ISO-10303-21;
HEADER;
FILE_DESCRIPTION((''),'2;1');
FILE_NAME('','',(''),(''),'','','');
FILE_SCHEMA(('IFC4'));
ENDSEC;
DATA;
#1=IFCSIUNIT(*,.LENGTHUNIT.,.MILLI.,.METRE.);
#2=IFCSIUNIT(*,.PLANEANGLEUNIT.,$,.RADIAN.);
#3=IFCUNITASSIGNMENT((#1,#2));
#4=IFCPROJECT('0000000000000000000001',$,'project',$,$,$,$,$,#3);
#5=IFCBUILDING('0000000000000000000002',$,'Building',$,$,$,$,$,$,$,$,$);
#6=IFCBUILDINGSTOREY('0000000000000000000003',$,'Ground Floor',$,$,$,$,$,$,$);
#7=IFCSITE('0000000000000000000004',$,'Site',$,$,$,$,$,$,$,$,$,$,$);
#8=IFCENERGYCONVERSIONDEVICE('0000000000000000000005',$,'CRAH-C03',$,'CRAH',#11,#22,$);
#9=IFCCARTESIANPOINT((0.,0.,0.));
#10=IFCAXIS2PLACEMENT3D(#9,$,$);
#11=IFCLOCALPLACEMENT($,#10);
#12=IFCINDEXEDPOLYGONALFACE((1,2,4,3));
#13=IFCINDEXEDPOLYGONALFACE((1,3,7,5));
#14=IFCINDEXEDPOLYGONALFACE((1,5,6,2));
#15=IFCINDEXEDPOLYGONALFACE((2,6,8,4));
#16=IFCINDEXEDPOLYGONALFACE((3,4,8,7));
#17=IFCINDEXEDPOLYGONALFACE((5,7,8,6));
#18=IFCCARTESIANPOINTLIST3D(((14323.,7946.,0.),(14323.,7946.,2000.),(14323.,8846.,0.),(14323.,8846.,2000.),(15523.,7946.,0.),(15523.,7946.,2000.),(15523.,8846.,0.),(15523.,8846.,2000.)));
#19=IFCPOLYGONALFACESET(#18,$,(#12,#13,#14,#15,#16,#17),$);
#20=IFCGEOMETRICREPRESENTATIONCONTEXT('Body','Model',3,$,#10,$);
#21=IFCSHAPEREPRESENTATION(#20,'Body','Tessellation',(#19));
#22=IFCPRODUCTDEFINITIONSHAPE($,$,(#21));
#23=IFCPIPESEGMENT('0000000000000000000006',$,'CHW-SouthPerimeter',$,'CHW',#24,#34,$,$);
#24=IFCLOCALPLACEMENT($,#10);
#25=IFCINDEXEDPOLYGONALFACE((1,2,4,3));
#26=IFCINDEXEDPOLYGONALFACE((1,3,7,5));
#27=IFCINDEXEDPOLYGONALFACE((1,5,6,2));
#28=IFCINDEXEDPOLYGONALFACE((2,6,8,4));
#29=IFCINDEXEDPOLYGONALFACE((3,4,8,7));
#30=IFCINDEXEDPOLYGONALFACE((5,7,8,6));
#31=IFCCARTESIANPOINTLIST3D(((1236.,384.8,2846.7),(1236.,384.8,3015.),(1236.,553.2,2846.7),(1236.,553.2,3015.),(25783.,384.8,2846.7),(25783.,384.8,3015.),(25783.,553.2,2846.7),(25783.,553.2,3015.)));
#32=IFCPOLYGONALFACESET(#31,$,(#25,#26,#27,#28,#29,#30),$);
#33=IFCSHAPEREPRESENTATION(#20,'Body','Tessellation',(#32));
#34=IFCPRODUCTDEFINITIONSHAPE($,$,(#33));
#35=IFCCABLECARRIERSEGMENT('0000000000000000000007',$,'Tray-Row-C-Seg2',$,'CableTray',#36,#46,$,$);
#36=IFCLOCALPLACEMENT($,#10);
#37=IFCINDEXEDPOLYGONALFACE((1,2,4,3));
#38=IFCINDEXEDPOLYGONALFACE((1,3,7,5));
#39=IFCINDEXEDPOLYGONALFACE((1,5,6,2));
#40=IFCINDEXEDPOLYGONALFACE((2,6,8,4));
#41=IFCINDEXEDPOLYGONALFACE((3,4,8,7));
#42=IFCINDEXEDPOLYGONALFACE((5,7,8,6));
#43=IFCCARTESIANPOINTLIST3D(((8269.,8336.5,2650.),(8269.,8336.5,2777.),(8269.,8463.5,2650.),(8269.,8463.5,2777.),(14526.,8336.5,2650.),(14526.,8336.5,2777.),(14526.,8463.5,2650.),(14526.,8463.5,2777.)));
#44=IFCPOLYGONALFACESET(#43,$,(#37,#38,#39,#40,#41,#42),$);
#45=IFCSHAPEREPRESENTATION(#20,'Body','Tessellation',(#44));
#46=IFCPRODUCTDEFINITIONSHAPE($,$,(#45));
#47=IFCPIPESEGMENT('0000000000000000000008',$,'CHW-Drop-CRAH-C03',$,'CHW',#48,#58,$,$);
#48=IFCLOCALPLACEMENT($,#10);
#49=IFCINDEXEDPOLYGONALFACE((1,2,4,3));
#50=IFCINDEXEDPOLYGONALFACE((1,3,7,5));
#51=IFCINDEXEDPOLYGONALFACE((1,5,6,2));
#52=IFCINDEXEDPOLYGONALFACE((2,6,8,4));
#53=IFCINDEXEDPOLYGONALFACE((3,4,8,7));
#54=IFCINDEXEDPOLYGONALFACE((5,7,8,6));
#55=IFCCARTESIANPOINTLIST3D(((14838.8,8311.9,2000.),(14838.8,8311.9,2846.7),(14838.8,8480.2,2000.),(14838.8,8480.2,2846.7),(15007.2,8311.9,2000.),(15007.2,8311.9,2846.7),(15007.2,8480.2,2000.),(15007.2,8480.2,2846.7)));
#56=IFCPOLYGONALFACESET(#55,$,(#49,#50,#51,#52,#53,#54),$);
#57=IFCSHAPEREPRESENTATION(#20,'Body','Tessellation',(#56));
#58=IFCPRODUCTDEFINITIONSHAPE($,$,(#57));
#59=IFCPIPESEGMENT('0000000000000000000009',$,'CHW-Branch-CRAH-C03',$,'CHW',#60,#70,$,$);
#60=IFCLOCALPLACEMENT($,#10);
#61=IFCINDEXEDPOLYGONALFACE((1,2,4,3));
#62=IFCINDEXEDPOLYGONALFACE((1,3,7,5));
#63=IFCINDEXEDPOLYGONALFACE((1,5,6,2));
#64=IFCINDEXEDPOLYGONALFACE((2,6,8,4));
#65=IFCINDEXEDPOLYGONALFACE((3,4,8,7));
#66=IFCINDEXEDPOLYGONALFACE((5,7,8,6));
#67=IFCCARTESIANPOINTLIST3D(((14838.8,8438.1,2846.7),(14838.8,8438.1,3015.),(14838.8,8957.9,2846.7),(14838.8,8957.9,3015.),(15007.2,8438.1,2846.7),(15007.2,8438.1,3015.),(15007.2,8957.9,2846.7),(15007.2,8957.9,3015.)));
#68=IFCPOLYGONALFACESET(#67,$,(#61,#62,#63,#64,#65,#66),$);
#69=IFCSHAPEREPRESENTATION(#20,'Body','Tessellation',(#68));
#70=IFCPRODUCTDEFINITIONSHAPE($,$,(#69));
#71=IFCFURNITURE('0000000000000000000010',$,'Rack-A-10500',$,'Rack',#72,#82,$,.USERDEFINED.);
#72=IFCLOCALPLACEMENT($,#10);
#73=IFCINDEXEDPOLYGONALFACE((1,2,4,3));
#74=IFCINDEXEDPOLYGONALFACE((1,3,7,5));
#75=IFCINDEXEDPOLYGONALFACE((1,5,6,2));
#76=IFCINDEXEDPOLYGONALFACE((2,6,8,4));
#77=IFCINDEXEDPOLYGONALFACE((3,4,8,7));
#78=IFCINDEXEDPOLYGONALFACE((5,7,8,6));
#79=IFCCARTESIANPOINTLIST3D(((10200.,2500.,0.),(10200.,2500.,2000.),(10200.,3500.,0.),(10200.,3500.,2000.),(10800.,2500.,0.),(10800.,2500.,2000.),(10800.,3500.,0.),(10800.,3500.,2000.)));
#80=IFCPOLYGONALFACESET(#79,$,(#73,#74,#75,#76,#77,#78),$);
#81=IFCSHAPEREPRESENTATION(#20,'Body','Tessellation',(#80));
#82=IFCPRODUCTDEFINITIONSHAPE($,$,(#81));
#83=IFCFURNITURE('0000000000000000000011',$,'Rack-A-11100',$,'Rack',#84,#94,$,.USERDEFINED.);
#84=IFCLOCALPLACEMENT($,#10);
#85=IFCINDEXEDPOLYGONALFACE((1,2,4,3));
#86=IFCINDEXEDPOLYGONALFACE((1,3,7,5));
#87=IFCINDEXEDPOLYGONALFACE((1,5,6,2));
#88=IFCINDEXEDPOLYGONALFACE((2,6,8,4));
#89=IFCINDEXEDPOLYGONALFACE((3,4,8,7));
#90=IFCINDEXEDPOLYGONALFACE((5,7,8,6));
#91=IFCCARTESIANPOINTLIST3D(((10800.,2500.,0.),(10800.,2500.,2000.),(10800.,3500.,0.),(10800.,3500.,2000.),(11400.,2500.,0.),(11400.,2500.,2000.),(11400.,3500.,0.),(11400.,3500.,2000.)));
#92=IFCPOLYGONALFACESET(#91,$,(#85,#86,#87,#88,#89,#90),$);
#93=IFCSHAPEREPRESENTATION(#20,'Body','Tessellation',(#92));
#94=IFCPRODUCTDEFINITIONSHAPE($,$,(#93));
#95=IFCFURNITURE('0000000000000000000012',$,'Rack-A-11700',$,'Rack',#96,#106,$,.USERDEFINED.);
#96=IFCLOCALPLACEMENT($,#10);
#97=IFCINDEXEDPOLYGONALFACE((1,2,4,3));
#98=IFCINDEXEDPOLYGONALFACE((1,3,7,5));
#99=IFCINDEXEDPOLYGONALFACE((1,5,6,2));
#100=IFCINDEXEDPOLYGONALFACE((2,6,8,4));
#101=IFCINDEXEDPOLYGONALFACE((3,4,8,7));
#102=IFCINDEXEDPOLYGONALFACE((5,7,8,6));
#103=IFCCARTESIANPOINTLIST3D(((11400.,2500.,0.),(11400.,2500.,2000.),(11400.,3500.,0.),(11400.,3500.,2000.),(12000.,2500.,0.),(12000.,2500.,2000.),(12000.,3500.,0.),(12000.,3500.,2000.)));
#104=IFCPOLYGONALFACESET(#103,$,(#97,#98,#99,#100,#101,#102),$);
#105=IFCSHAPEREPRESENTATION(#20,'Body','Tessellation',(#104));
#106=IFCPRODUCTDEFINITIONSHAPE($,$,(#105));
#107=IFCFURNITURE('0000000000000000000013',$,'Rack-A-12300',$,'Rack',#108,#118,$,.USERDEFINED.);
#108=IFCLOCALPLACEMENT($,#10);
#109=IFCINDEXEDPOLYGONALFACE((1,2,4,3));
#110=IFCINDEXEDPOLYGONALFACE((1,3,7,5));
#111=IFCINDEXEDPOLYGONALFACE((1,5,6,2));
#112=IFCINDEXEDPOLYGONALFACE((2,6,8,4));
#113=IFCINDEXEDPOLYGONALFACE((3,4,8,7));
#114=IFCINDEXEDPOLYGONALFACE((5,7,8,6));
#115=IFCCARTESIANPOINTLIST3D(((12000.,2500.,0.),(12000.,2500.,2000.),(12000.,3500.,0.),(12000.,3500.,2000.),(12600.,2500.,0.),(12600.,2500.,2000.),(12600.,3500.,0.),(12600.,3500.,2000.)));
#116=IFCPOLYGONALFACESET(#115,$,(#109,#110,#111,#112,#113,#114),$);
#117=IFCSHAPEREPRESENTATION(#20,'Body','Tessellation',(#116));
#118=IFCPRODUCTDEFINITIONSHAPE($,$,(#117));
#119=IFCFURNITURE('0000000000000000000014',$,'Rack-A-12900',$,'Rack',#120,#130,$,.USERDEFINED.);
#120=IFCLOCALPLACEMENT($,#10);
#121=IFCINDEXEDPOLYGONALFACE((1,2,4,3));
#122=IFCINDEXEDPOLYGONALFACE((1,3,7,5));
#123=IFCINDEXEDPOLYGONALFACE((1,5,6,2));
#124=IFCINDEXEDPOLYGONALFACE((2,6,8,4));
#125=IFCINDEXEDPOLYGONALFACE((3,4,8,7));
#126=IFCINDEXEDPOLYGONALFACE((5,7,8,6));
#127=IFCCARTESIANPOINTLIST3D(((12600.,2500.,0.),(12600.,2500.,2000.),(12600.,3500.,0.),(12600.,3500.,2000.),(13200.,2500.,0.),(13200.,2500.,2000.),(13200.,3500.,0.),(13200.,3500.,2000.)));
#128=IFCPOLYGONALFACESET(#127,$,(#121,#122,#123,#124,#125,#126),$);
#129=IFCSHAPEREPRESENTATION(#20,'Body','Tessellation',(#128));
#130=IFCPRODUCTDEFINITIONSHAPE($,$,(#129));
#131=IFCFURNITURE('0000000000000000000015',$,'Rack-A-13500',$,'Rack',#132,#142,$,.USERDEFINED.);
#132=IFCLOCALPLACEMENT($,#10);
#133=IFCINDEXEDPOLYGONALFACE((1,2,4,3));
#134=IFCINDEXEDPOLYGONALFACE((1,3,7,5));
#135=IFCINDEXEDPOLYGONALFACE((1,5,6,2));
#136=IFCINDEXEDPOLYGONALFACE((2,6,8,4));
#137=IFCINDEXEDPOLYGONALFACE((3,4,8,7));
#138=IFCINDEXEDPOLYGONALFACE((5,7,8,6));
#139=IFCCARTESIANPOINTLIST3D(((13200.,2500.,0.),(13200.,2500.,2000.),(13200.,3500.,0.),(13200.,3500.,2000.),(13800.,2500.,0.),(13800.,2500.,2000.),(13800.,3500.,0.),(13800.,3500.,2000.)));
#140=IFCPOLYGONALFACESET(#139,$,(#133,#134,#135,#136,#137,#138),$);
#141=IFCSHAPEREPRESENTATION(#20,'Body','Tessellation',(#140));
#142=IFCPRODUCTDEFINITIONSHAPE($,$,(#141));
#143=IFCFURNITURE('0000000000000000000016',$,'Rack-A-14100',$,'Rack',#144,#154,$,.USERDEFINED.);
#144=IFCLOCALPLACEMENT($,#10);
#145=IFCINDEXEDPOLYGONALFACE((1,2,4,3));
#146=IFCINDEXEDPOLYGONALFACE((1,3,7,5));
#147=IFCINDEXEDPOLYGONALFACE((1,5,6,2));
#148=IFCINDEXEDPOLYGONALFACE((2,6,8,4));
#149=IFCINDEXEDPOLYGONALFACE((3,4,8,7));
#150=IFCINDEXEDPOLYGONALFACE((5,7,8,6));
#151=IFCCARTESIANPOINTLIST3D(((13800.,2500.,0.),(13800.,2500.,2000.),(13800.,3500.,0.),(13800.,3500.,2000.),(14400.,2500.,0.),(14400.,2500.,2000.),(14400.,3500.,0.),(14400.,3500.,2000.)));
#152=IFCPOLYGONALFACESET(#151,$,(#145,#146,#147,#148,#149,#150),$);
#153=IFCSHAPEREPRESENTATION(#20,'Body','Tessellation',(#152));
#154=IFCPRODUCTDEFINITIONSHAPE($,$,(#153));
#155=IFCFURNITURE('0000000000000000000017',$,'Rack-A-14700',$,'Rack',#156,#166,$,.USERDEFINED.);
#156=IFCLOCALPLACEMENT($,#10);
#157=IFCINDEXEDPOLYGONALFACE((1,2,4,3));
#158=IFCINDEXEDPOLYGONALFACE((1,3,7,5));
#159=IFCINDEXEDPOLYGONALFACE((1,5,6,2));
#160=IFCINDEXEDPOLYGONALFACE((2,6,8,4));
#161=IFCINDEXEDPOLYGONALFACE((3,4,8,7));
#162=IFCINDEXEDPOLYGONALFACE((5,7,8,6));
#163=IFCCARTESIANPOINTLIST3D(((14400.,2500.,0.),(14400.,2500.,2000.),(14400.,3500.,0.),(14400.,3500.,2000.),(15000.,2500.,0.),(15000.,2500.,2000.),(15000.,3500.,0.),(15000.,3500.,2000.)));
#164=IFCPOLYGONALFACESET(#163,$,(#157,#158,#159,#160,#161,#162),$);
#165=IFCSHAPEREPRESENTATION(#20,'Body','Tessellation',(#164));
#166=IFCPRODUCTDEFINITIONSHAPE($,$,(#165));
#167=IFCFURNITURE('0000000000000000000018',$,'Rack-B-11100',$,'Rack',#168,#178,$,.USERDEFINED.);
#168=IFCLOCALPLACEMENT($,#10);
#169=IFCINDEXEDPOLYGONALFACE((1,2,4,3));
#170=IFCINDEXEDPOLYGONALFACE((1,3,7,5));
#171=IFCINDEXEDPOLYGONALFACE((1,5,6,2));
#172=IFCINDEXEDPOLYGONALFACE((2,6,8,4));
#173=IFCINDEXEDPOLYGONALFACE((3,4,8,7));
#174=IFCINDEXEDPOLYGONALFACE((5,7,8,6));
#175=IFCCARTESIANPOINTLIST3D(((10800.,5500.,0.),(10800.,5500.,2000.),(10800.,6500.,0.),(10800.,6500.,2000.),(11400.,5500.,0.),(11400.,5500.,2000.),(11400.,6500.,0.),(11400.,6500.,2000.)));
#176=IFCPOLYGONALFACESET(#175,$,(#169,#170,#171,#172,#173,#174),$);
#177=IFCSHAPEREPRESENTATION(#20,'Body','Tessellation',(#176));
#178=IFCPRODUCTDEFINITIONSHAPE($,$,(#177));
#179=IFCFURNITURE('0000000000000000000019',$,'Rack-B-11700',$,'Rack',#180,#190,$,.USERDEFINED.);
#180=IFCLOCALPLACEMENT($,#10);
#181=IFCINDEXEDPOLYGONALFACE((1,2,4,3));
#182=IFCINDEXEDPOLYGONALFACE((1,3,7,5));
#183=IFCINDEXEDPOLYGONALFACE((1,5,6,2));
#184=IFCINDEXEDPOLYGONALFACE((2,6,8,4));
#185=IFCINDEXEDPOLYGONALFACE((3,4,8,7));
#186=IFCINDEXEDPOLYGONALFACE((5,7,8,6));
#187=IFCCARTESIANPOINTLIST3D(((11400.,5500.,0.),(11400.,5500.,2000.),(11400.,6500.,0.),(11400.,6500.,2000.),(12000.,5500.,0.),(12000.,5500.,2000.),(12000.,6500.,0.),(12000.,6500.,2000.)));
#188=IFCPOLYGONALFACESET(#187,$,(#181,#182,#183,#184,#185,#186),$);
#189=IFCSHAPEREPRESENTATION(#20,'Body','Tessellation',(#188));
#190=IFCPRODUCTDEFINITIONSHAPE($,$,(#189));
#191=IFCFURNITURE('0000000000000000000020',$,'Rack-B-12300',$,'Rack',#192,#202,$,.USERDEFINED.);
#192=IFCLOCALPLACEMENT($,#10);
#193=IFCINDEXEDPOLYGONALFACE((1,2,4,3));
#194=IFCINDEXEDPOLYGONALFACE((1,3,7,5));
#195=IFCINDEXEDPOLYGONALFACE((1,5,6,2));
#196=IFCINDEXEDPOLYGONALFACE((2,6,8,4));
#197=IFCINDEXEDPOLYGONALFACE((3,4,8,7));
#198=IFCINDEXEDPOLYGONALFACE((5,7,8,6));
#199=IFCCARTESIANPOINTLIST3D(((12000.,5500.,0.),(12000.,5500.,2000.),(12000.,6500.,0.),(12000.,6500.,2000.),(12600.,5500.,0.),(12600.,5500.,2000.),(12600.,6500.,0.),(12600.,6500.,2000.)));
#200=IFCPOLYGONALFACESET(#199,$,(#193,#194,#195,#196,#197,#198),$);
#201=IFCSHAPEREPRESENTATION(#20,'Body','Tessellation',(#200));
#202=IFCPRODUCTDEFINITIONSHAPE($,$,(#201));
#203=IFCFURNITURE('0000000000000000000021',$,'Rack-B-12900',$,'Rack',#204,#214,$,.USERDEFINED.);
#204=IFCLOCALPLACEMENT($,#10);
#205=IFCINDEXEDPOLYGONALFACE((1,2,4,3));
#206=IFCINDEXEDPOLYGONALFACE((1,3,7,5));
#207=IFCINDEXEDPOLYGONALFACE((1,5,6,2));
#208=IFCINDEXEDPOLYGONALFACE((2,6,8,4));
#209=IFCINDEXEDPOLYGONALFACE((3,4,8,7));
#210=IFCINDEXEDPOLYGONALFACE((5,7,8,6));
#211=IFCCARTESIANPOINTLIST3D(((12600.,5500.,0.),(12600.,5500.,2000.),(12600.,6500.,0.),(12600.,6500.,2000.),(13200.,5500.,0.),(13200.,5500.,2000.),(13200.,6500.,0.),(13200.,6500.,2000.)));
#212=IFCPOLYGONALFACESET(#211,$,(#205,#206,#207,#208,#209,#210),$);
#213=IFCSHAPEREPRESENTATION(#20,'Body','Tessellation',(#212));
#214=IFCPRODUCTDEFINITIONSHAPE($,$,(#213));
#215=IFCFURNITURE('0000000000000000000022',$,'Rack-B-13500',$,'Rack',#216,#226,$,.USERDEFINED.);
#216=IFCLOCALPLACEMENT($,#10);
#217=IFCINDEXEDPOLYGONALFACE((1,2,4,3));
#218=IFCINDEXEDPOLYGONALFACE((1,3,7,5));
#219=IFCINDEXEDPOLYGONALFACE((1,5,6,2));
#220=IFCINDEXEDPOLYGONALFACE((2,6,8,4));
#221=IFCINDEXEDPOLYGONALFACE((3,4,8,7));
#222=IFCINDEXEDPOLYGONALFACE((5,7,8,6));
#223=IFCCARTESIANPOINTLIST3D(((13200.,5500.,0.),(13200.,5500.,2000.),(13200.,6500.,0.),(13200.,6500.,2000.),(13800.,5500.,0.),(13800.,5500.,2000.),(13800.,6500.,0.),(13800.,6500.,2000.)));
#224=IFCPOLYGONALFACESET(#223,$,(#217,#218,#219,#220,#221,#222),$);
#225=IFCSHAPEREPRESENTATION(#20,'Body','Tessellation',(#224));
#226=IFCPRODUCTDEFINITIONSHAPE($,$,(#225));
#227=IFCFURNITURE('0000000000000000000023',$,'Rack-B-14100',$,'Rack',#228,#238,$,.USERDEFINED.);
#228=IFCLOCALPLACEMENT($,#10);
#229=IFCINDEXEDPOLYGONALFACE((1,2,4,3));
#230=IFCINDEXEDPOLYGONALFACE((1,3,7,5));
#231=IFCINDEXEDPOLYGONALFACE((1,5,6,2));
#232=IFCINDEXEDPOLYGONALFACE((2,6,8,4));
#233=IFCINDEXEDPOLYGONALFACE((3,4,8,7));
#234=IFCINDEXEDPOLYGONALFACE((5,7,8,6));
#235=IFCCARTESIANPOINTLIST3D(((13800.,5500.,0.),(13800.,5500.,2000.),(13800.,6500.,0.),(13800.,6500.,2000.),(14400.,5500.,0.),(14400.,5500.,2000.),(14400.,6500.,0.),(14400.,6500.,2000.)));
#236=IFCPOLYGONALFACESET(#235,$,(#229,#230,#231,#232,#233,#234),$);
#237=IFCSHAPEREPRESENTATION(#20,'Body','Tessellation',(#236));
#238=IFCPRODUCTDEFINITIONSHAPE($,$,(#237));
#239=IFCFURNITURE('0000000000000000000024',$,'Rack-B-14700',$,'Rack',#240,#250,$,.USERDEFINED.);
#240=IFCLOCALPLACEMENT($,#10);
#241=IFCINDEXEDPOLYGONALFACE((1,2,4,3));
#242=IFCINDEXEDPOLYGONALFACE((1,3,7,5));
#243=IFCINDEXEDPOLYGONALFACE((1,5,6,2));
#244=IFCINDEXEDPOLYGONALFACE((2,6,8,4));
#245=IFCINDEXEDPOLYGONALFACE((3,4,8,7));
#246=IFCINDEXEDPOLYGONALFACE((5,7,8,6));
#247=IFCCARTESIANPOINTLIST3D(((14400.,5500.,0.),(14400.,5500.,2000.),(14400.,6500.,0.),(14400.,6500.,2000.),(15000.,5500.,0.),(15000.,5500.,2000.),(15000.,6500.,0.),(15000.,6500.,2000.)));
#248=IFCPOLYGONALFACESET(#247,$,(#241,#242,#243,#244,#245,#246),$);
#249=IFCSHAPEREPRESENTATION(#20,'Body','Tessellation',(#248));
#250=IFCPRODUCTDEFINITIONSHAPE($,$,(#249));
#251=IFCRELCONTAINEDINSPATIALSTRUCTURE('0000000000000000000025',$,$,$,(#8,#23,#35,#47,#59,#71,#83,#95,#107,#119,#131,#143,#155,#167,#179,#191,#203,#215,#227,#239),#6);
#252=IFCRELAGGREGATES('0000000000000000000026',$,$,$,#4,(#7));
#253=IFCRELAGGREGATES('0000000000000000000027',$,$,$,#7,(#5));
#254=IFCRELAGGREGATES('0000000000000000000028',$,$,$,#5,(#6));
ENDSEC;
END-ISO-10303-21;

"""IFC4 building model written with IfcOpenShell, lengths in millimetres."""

from ifc_helpers import new_model, si_unit, frame, origin, place, context, project, spatial, rectangle, extrude, element, save


model = new_model("IFC4")

# Units and contexts
model_context = context("Model", 3, world=origin(), identifier="Body")
ifc_project = project(units=[si_unit("LENGTHUNIT", "METRE", prefix="MILLI"), si_unit("PLANEANGLEUNIT", "RADIAN")])

# Site, building, storey
site = spatial("IfcSite", under=ifc_project, Name="Site")
building = spatial("IfcBuilding", under=site, Name="Building")
storey = spatial("IfcBuildingStorey", under=building, Name="Ground Floor")

# Energy conversion device
energy_conversion_device_placement = place(None, frame((14923.0, 8396.0, 0.0), z_axis=(0.0, 0.0, 1.0), x_axis=(1.0, 0.0, 0.0)))
element("IfcEnergyConversionDevice", 1, at=energy_conversion_device_placement, inside=storey, Name="CRAH-C03", ObjectType="CRAH", context=model_context, shape_type="SweptSolid", body=[
    extrude(rectangle(XDim=1200.0, YDim=900.0), origin(), (0.0, 0.0, 1.0), 2000.0),
])

# Pipe segment
pipe_segment_1_placement = place(None, frame((13509.5, 469.0, 2846.7), z_axis=(0.0, 0.0, 1.0), x_axis=(1.0, 0.0, 0.0)))
element("IfcPipeSegment", 2, at=pipe_segment_1_placement, inside=storey, Name="CHW-SouthPerimeter", ObjectType="CHW", context=model_context, shape_type="SweptSolid", body=[
    extrude(rectangle(XDim=24547.0, YDim=168.3), origin(), (0.0, 0.0, 1.0), 168.3),
])

# Cable carrier segment
cable_carrier_segment_placement = place(None, frame((11397.5, 8400.0, 2650.0), z_axis=(0.0, 0.0, 1.0), x_axis=(1.0, 0.0, 0.0)))
element("IfcCableCarrierSegment", 3, at=cable_carrier_segment_placement, inside=storey, Name="Tray-Row-C-Seg2", ObjectType="CableTray", context=model_context, shape_type="SweptSolid", body=[
    extrude(rectangle(XDim=6257.0, YDim=127.0), origin(), (0.0, 0.0, 1.0), 127.0),
])

# Pipe segments
pipe_segment_2_placement = place(None, frame((14923.0, 8396.0, 2000.0), z_axis=(0.0, 0.0, 1.0), x_axis=(1.0, 0.0, 0.0)))
element("IfcPipeSegment", 4, at=pipe_segment_2_placement, inside=storey, Name="CHW-Drop-CRAH-C03", ObjectType="CHW", context=model_context, shape_type="SweptSolid", body=[
    extrude(rectangle(XDim=168.3, YDim=168.3), origin(), (0.0, 0.0, 1.0), 846.7),
])
pipe_segment_3_placement = place(None, frame((14923.0, 8698.0, 2846.7), z_axis=(0.0, 0.0, 1.0), x_axis=(1.0, 0.0, 0.0)))
element("IfcPipeSegment", 5, at=pipe_segment_3_placement, inside=storey, Name="CHW-Branch-CRAH-C03", ObjectType="CHW", context=model_context, shape_type="SweptSolid", body=[
    extrude(rectangle(XDim=168.3, YDim=519.9), origin(), (0.0, 0.0, 1.0), 168.3),
])

# Furniture
for number, where, z_axis, x_axis, name in (
    (6, (10500.0, 3000.0, 0.0), (0.0, 0.0, 1.0), (1.0, 0.0, 0.0), "Rack-A-10500"),
    (7, (11100.0, 3000.0, 0.0), (0.0, 0.0, 1.0), (1.0, 0.0, 0.0), "Rack-A-11100"),
    (8, (11700.0, 3000.0, 0.0), (0.0, 0.0, 1.0), (1.0, 0.0, 0.0), "Rack-A-11700"),
    (9, (12300.0, 3000.0, 0.0), (0.0, 0.0, 1.0), (1.0, 0.0, 0.0), "Rack-A-12300"),
    (10, (12900.0, 3000.0, 0.0), (0.0, 0.0, 1.0), (1.0, 0.0, 0.0), "Rack-A-12900"),
    (11, (13500.0, 3000.0, 0.0), (0.0, 0.0, 1.0), (1.0, 0.0, 0.0), "Rack-A-13500"),
    (12, (14100.0, 3000.0, 0.0), (0.0, 0.0, 1.0), (1.0, 0.0, 0.0), "Rack-A-14100"),
    (13, (14700.0, 3000.0, 0.0), (0.0, 0.0, 1.0), (1.0, 0.0, 0.0), "Rack-A-14700"),
    (14, (11100.0, 6000.0, 0.0), (0.0, 0.0, 1.0), (1.0, 0.0, 0.0), "Rack-B-11100"),
    (15, (11700.0, 6000.0, 0.0), (0.0, 0.0, 1.0), (1.0, 0.0, 0.0), "Rack-B-11700"),
    (16, (12300.0, 6000.0, 0.0), (0.0, 0.0, 1.0), (1.0, 0.0, 0.0), "Rack-B-12300"),
    (17, (12900.0, 6000.0, 0.0), (0.0, 0.0, 1.0), (1.0, 0.0, 0.0), "Rack-B-12900"),
    (18, (13500.0, 6000.0, 0.0), (0.0, 0.0, 1.0), (1.0, 0.0, 0.0), "Rack-B-13500"),
    (19, (14100.0, 6000.0, 0.0), (0.0, 0.0, 1.0), (1.0, 0.0, 0.0), "Rack-B-14100"),
    (20, (14700.0, 6000.0, 0.0), (0.0, 0.0, 1.0), (1.0, 0.0, 0.0), "Rack-B-14700"),
):
    element("IfcFurniture", number, at=place(None, frame(where, z_axis=z_axis, x_axis=x_axis)), inside=storey, Name=name, ObjectType="Rack", PredefinedType="USERDEFINED", context=model_context, shape_type="SweptSolid", body=[
        extrude(rectangle(XDim=600.0, YDim=1000.0), origin(), (0.0, 0.0, 1.0), 2000.0),
    ])

save(model, "model.ifc")
